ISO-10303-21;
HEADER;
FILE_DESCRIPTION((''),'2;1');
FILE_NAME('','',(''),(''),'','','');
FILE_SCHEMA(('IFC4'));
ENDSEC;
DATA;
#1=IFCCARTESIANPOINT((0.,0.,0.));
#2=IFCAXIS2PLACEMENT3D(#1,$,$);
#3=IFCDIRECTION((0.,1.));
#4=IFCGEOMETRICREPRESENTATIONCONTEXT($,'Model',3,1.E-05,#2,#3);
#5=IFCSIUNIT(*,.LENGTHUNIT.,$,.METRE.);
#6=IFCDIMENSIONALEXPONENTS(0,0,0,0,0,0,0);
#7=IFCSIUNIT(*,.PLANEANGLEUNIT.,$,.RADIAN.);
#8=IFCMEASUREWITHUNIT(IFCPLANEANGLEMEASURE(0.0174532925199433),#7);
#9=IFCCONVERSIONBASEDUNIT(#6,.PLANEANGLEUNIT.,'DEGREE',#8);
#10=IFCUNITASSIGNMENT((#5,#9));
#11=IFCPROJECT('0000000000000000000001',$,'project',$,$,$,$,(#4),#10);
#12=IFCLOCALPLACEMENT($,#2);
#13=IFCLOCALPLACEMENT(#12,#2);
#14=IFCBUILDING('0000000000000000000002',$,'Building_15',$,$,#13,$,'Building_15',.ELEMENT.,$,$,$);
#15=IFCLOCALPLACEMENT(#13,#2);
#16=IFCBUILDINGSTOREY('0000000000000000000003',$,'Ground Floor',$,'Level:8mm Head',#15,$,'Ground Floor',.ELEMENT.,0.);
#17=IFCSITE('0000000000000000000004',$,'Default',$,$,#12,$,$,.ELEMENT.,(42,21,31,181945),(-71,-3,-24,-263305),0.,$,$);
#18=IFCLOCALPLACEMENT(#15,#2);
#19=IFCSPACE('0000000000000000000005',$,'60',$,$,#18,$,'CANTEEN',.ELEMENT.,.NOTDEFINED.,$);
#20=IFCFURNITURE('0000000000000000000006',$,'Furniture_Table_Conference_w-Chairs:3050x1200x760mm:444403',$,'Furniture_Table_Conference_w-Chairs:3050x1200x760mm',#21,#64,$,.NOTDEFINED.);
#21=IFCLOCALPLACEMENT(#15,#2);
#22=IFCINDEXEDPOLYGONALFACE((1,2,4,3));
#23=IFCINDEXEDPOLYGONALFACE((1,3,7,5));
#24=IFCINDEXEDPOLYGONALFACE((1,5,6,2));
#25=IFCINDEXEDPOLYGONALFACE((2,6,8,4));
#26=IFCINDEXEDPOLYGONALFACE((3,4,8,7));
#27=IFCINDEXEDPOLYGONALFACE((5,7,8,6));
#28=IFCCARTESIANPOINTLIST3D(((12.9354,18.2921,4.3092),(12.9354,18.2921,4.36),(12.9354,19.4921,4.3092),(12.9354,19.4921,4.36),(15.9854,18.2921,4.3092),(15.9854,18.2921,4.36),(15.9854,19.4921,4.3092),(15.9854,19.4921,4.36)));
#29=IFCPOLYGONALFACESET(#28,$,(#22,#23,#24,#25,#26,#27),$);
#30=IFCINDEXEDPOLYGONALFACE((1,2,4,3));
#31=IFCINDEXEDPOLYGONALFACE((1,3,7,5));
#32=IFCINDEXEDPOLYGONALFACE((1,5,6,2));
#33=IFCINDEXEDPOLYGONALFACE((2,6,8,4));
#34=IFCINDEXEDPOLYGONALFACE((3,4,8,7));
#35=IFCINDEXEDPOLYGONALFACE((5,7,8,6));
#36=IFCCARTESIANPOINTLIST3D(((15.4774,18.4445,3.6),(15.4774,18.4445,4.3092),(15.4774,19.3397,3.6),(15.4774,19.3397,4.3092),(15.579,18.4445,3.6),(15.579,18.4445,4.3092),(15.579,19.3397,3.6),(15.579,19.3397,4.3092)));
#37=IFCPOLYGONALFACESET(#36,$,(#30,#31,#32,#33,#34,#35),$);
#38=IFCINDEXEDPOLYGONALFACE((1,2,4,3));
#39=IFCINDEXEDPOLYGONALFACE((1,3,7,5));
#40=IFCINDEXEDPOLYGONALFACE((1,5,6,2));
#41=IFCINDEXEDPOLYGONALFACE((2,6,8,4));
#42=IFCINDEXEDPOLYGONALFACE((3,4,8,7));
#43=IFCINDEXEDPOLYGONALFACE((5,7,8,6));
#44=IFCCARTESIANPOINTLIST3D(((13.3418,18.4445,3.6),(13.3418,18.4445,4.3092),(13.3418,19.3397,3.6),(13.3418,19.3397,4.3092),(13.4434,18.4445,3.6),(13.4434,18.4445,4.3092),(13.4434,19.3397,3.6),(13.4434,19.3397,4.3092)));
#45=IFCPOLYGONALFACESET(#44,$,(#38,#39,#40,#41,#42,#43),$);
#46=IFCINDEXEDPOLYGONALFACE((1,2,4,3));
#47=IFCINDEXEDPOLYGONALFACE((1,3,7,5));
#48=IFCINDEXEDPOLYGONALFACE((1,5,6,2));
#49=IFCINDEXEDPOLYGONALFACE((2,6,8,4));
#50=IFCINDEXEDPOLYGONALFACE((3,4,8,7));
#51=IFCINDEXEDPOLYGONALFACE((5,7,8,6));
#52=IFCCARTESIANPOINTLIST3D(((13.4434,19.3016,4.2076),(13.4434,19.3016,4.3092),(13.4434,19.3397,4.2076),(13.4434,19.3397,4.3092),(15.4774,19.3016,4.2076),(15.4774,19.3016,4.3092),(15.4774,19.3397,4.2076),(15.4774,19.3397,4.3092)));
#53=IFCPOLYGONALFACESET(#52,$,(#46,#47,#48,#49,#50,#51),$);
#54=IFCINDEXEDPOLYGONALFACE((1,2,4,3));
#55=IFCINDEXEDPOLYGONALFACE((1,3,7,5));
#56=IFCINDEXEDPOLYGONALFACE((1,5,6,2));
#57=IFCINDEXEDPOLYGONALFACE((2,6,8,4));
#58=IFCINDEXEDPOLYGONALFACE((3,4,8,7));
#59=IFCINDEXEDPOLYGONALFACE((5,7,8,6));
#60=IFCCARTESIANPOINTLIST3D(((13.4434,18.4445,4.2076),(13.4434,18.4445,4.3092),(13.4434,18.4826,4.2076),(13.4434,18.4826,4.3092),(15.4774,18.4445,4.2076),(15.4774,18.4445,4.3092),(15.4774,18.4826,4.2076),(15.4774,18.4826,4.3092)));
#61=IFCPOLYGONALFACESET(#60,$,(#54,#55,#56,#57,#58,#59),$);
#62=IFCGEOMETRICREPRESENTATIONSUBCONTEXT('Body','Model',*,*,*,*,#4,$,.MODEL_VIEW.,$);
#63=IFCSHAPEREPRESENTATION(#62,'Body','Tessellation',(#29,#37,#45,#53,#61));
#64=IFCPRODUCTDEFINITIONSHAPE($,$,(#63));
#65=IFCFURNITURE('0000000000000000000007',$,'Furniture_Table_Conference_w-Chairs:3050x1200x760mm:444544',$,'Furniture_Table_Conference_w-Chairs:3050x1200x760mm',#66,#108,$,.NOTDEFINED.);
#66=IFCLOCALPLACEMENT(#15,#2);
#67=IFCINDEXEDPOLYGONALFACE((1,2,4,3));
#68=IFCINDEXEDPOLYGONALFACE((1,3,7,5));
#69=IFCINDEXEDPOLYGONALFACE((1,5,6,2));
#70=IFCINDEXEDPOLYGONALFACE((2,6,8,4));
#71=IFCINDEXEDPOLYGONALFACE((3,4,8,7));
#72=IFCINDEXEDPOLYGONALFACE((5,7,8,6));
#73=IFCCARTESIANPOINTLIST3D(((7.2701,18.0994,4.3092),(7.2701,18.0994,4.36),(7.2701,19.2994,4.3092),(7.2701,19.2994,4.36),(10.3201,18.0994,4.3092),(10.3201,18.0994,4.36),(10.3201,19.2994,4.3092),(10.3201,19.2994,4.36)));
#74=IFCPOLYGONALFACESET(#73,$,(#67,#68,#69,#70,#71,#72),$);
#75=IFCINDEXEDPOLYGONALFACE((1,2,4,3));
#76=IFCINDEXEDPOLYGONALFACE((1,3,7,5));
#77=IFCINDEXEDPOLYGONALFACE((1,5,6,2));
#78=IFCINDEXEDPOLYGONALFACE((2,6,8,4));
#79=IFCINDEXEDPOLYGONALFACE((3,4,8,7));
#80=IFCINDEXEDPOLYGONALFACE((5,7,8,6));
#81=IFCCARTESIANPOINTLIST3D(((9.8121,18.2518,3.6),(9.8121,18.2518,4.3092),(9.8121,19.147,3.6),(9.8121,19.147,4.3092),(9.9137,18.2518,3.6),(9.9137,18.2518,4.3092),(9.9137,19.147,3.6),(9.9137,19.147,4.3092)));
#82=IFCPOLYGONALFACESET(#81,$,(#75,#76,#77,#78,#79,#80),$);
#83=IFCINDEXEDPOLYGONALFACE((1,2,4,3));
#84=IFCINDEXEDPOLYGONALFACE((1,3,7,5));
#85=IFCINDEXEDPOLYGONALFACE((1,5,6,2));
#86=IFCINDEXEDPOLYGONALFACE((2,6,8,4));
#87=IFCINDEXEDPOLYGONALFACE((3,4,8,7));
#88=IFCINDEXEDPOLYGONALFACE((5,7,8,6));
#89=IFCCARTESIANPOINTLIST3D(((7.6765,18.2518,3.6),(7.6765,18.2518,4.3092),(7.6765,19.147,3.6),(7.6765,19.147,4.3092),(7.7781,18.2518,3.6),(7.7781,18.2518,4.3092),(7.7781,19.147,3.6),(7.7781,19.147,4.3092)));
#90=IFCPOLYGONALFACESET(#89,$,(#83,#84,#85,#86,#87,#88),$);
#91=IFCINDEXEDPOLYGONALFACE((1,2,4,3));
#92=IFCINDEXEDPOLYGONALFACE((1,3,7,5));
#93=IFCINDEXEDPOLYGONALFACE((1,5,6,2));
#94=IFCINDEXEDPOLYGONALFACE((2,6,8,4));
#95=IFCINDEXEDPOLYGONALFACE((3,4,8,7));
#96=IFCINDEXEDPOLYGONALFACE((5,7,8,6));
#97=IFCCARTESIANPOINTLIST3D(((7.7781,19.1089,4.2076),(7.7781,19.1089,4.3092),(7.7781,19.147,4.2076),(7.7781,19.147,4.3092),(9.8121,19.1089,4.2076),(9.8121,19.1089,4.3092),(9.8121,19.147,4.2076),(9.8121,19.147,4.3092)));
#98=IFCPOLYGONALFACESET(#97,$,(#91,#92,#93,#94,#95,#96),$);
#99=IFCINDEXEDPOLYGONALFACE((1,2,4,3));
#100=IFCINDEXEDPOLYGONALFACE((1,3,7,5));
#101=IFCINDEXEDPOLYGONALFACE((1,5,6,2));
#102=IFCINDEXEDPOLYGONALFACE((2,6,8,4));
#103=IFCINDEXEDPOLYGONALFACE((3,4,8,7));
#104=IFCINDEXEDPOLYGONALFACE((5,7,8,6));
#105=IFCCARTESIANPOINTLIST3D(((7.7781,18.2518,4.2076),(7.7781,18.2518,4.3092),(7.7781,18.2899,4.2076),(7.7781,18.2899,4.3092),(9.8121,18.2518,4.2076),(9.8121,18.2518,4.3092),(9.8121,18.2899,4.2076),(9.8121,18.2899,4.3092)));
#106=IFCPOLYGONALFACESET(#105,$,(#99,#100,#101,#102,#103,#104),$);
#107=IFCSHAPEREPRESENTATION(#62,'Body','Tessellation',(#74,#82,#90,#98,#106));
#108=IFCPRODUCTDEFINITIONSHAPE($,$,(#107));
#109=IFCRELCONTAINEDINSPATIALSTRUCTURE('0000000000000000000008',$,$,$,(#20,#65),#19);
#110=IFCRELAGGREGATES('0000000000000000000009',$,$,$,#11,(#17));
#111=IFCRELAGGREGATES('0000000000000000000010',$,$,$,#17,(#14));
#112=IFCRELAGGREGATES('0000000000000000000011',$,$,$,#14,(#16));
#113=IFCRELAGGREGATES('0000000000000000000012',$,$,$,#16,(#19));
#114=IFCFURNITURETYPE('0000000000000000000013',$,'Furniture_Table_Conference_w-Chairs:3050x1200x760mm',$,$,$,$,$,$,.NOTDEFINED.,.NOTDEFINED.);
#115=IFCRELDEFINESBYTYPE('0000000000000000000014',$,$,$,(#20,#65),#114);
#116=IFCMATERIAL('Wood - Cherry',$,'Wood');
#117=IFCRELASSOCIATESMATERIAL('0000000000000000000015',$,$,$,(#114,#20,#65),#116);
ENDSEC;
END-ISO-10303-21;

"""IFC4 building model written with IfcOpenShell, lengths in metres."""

from ifc_helpers import new_model, entity, si_unit, converted_unit, direction, frame, origin, place, context, subcontext, project, spatial, indexed_curve, outline, extrude, source, transform, mapped, material, type_object, type_shapes, element, save


model = new_model("IFC4")

# Units and contexts
model_context = context("Model", 3, precision=1e-05, world=origin(), true_north=direction((0.0, 1.0)))
body_context = subcontext(model_context, "Body", "Model", "MODEL_VIEW")
ifc_project = project(units=[si_unit("LENGTHUNIT", "METRE"), converted_unit("PLANEANGLEUNIT", "DEGREE", entity("IfcPlaneAngleMeasure", 0.0174532925199433), si_unit("PLANEANGLEUNIT", "RADIAN"), dimensions=[0, 0, 0, 0, 0, 0, 0])], contexts=[model_context])

# Site, building, storey
site_placement = place(None, origin())
site = spatial("IfcSite", under=ifc_project, at=site_placement, Name="Default", CompositionType="ELEMENT", RefLatitude=(42, 21, 31, 181945), RefLongitude=(-71, -3, -24, -263305), RefElevation=0.0)
building_placement = place(site_placement, origin())
building = spatial("IfcBuilding", under=site, at=building_placement, Name="Building_15", LongName="Building_15", CompositionType="ELEMENT")
storey_placement = place(building_placement, origin())
storey = spatial("IfcBuildingStorey", under=building, at=storey_placement, Name="Ground Floor", ObjectType="Level:8mm Head", LongName="Ground Floor", CompositionType="ELEMENT", Elevation=0.0)

# Shared definitions
space_placement = place(storey_placement, origin())
space = spatial("IfcSpace", under=storey, at=space_placement, Name="60", LongName="CANTEEN", CompositionType="ELEMENT", PredefinedType="NOTDEFINED")

# Furniture
ifc_material_1 = material(Name="Wood - Cherry", Category="Wood")
furniture_type_1 = type_object("IfcFurnitureType", Name="Furniture_Table_Conference_w-Chairs:3050x1200x760mm", AssemblyPlace="NOTDEFINED", PredefinedType="NOTDEFINED", material=ifc_material_1)
shared_shape_1 = source(origin(), body_context, "Body", "SweptSolid", [
    extrude(outline(indexed_curve([(-0.6, -1.525), (0.6, -1.525), (0.6, 1.525), (-0.6, 1.525), (-0.6, -1.525)], self_intersect=False)), frame((0.0, 0.0, 0.7092), z_axis=(0.0, 0.0, 1.0), x_axis=(0.0, 1.0, 0.0)), (0.0, 0.0, 1.0), 0.0508),
    extrude(outline(indexed_curve([(-0.4476, -0.0508), (0.4476, -0.0508), (0.4476, 0.0508), (-0.4476, 0.0508), (-0.4476, -0.0508)], self_intersect=False)), frame((1.0678, 0.0, 0.0), z_axis=(0.0, 0.0, 1.0), x_axis=(0.0, 1.0, 0.0)), (0.0, 0.0, 1.0), 0.7092),
    extrude(outline(indexed_curve([(-0.4476, -0.0508), (0.4476, -0.0508), (0.4476, 0.0508), (-0.4476, 0.0508), (-0.4476, -0.0508)], self_intersect=False)), frame((-1.0678, 0.0, 0.0), z_axis=(0.0, 0.0, 1.0), x_axis=(0.0, 1.0, 0.0)), (0.0, 0.0, 1.0), 0.7092),
    extrude(outline(indexed_curve([(-1.017, -0.0191), (1.017, -0.0191), (1.017, 0.0191), (-1.017, 0.0191), (-1.017, -0.0191)], self_intersect=False)), frame((0.0, 0.4286, 0.6076), z_axis=(0.0, 0.0, 1.0), x_axis=(-1.0, 0.0, 0.0)), (0.0, 0.0, 1.0), 0.1016),
    extrude(outline(indexed_curve([(-0.019, -1.017), (0.019, -1.017), (0.019, 1.017), (-0.019, 1.017), (-0.019, -1.017)], self_intersect=False)), frame((0.0, -0.4286, 0.6076), z_axis=(0.0, 0.0, 1.0), x_axis=(0.0, 1.0, 0.0)), (0.0, 0.0, 1.0), 0.1016),
])
type_shapes(furniture_type_1, [shared_shape_1])
for number, where, name in (
    (1, (14.4604, 18.8921, 3.6), "Furniture_Table_Conference_w-Chairs:3050x1200x760mm:444403"),
    (2, (8.7951, 18.6994, 3.6), "Furniture_Table_Conference_w-Chairs:3050x1200x760mm:444544"),
):
    element("IfcFurniture", number, at=place(space_placement, frame(where)), inside=space, type_object=furniture_type_1, material=ifc_material_1, Name=name, ObjectType="Furniture_Table_Conference_w-Chairs:3050x1200x760mm", PredefinedType="NOTDEFINED", context=body_context, shape_type="MappedRepresentation", body=[
        mapped(shared_shape_1, transform((0.0, 0.0, 0.0), scale=1.0)),
    ])

save(model, "model.ifc")
